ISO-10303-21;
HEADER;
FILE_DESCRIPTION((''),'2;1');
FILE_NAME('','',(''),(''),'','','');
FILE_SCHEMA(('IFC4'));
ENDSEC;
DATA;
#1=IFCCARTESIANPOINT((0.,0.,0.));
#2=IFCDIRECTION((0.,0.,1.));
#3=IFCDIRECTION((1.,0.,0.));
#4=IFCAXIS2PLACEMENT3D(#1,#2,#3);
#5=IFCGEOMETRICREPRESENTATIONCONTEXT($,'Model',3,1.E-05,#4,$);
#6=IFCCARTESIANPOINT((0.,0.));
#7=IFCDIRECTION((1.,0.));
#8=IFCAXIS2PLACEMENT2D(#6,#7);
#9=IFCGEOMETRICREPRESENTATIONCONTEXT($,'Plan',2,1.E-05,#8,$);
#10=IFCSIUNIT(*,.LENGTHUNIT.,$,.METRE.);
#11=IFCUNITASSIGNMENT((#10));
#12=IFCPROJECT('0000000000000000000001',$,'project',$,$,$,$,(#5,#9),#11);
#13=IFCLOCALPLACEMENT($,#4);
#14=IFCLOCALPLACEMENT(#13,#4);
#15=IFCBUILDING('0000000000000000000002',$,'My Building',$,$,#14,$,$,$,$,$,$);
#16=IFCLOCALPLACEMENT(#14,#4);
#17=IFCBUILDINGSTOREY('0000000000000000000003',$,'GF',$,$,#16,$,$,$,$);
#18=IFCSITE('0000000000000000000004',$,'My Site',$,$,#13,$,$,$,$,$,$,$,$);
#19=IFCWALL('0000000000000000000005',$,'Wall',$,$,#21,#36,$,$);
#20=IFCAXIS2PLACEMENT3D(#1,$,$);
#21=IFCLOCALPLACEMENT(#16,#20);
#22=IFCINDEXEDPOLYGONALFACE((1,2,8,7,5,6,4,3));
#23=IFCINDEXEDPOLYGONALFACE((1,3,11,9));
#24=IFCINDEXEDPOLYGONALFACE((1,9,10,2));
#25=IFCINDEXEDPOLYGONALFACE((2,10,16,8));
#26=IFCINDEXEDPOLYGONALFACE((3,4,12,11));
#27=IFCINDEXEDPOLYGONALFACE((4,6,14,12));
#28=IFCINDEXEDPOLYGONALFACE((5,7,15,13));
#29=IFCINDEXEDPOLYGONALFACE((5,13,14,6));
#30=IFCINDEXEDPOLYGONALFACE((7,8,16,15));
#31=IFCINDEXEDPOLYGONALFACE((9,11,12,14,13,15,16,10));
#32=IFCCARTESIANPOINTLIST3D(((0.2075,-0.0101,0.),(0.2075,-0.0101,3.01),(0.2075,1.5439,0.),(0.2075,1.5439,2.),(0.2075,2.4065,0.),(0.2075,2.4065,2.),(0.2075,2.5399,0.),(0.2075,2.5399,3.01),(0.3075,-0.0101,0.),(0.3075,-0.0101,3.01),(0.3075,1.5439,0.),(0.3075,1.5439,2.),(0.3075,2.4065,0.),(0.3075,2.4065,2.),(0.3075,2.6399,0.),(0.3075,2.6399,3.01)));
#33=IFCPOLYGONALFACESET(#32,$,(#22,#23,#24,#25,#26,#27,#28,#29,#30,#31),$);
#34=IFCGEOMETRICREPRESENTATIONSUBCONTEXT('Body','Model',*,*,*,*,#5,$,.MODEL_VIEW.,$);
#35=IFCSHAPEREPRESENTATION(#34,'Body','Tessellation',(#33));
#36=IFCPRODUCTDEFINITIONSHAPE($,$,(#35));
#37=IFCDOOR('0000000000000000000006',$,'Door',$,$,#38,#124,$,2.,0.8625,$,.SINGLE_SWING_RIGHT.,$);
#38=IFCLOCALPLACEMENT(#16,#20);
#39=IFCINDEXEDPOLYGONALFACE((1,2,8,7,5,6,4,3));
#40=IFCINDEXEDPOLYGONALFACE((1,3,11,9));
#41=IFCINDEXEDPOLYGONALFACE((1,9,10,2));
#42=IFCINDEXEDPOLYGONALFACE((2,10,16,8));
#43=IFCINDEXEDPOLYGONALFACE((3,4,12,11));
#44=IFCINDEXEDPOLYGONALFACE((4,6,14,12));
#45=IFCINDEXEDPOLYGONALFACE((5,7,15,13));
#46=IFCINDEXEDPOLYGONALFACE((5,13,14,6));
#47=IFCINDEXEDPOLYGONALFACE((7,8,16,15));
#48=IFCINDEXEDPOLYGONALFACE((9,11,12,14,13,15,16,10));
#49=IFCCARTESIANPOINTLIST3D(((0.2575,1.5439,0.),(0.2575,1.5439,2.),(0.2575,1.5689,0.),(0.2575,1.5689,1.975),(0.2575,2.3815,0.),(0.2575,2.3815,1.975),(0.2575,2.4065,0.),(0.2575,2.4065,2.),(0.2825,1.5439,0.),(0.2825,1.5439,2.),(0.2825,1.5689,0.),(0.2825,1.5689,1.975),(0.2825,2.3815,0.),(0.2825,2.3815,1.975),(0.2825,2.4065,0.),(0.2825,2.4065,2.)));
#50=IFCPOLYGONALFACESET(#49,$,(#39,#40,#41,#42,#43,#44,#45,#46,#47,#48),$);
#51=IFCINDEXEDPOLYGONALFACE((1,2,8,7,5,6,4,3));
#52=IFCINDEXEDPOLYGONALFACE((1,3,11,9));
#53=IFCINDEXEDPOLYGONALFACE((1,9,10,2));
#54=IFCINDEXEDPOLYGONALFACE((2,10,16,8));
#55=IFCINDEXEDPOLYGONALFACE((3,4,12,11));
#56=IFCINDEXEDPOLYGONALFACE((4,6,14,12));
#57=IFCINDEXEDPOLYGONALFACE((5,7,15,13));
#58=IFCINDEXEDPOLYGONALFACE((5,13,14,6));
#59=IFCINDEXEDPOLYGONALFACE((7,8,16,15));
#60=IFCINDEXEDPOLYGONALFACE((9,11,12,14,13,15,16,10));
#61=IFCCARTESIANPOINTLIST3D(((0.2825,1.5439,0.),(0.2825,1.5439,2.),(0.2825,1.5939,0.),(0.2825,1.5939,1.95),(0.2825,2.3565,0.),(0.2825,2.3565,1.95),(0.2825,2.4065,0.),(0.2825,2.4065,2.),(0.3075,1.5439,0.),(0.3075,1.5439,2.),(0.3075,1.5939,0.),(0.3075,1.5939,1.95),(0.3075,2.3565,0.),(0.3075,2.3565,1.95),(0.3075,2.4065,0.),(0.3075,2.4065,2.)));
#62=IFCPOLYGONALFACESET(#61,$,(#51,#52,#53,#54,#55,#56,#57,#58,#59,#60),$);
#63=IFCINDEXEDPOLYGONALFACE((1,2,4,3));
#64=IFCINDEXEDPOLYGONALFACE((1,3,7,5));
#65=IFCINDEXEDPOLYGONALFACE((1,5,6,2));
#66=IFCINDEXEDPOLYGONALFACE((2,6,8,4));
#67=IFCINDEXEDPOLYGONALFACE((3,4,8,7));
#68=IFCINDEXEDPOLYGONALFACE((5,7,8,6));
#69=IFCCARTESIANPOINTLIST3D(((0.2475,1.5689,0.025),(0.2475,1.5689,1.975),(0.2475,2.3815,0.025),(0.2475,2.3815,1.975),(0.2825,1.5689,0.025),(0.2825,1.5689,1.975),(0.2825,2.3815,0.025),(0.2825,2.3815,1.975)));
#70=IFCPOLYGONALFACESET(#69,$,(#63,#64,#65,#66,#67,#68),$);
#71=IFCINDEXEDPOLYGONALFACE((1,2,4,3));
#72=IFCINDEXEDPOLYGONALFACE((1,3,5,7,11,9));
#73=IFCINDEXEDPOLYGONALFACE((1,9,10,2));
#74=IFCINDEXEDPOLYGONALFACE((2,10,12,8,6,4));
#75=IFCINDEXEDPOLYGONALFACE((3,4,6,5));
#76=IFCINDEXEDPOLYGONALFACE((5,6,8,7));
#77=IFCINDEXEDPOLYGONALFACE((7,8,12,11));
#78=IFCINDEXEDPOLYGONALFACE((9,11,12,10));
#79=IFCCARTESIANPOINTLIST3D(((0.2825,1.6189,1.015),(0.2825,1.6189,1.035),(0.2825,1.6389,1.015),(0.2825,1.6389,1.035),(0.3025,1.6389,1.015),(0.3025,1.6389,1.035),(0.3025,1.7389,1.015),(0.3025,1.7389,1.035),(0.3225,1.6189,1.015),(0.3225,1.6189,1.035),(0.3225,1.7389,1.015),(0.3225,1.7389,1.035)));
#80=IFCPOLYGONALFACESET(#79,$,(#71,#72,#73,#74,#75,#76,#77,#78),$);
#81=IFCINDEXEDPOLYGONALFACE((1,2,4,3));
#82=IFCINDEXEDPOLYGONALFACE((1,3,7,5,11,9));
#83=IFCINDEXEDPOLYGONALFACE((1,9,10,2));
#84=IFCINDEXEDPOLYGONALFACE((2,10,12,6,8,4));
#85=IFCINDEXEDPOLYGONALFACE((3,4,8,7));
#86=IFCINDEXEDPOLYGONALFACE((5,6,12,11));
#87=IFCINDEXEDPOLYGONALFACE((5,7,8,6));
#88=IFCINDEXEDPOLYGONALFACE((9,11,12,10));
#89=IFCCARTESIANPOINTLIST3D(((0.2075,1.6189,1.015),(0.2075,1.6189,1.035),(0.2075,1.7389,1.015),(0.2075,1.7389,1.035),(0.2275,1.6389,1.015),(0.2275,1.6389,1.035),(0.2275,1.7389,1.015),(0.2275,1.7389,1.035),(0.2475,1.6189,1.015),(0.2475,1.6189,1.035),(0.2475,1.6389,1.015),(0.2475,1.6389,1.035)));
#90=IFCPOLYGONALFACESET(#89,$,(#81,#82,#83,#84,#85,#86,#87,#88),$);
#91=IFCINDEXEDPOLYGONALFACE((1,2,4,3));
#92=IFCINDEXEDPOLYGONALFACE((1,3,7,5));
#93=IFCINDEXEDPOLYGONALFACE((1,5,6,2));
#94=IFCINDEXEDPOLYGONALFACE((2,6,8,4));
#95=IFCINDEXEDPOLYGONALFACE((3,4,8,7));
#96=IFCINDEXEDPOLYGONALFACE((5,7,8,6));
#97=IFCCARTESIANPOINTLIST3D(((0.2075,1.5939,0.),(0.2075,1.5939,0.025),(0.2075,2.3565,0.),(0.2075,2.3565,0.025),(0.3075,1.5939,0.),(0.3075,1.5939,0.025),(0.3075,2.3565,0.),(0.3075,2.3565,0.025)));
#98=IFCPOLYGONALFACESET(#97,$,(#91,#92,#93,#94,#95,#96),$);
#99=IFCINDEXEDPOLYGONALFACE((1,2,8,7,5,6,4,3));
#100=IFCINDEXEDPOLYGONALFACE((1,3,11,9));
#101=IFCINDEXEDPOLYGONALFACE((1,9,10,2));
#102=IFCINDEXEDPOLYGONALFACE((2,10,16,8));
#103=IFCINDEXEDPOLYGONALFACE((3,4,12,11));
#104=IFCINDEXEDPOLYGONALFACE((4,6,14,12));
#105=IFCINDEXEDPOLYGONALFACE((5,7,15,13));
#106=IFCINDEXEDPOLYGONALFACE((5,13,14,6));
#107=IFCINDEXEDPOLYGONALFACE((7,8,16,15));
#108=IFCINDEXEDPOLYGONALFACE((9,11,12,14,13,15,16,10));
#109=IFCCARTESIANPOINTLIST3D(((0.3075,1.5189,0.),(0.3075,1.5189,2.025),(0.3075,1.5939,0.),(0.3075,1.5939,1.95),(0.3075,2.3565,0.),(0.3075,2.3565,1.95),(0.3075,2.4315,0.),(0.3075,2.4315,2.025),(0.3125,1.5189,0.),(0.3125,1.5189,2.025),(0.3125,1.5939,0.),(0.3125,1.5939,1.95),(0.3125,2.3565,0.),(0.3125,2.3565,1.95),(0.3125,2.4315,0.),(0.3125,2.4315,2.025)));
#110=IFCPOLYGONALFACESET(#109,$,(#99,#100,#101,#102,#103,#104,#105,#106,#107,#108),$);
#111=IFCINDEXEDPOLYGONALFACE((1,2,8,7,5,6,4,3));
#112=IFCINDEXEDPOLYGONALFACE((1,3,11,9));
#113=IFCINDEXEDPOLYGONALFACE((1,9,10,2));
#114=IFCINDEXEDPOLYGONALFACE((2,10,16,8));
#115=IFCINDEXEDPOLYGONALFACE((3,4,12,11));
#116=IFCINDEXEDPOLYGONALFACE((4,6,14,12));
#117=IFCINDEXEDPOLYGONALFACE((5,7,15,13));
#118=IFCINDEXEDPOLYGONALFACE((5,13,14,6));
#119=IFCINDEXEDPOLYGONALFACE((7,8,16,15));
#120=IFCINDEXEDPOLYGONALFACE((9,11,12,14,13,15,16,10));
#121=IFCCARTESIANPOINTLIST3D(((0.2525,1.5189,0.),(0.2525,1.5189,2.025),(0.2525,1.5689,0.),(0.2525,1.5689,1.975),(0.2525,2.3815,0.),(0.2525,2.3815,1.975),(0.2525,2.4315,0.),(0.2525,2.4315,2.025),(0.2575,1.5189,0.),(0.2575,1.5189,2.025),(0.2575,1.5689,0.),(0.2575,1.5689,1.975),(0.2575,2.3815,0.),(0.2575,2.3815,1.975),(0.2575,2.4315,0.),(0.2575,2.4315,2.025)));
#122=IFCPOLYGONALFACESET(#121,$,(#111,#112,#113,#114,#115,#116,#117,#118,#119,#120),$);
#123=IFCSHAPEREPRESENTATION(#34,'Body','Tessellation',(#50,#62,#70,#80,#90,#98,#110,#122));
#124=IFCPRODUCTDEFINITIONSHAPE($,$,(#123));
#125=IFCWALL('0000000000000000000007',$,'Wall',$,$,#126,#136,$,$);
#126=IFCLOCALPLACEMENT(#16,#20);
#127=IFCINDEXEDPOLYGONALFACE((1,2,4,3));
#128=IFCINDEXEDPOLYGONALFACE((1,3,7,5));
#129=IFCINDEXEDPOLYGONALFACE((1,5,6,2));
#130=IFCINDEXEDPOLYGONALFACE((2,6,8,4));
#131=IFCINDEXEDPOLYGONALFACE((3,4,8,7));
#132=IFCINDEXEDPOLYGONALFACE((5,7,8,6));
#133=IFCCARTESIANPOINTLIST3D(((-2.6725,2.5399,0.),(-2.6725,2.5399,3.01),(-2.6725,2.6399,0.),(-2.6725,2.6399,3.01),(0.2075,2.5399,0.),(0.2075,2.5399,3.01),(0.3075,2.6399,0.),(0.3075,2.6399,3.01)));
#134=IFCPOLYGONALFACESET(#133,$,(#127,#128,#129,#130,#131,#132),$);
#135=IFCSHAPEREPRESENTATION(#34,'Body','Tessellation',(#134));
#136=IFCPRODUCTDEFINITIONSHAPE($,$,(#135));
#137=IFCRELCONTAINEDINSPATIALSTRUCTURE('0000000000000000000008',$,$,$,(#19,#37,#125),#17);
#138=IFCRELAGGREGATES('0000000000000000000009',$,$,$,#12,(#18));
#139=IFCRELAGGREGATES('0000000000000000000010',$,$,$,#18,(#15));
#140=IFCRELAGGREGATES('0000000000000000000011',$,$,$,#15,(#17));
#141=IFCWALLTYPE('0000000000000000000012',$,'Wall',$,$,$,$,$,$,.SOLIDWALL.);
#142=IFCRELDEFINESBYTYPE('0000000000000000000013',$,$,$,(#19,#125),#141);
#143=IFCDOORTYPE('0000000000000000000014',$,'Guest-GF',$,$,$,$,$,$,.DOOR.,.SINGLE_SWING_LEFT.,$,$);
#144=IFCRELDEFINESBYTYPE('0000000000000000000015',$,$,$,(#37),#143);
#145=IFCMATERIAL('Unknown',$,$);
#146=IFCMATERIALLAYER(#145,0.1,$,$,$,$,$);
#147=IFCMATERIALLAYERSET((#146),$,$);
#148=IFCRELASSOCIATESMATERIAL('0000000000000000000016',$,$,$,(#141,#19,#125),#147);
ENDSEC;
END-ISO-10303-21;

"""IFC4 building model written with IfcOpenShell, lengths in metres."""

from ifc_helpers import new_model, entity, si_unit, frame, origin_with_axes, origin_2d_with_axis, place, context, subcontext, project, spatial, line, indexed_curve, outline, extrude, shape, source, transform, mapped, material, layer, layer_set, layer_usage, type_object, type_shapes, element, fill, save


model = new_model("IFC4")

# Units and contexts
model_context = context("Model", 3, precision=1e-05, world=origin_with_axes())
plan_context = context("Plan", 2, precision=1e-05, world=origin_2d_with_axis())
body_context_1 = subcontext(model_context, "Body", "Model", "MODEL_VIEW")
body_context_2 = subcontext(plan_context, "Body", "Plan", "PLAN_VIEW")
ifc_project = project(units=[si_unit("LENGTHUNIT", "METRE")], contexts=[model_context, plan_context])

# Site, building, storey
site_placement = place(None, origin_with_axes())
site = spatial("IfcSite", under=ifc_project, at=site_placement, Name="My Site")
building_placement = place(site_placement, origin_with_axes())
building = spatial("IfcBuilding", under=site, at=building_placement, Name="My Building")
storey_placement = place(building_placement, origin_with_axes())
storey = spatial("IfcBuildingStorey", under=building, at=storey_placement, Name="GF")

# Shared definitions
ifc_material = material(Name="Unknown")

# Shared definitions
ifc_layer_1 = layer(ifc_material, 0.1)
ifc_layer_set_1 = layer_set([ifc_layer_1])
wall_type = type_object("IfcWallType", Name="Wall", PredefinedType="SOLIDWALL", material=ifc_layer_set_1)

# Wall, opening, door
ifc_layer_usage_1 = layer_usage(ifc_layer_set_1, "AXIS2", "POSITIVE", 0.0)
wall_1_placement = place(storey_placement, frame((0.3075, -0.0101, 0.0), z_axis=(0.0, 0.0, 1.0), x_axis=(0.0, 1.0, 0.0)))
wall_1 = element("IfcWall", 1, at=wall_1_placement, inside=storey, type_object=wall_type, material=ifc_layer_usage_1, Name="Wall", context=body_context_1, shape_type="SweptSolid", body=[
    extrude(outline(indexed_curve([(0.0, 0.0), (0.0, 0.1), (2.55, 0.1), (2.65, 0.0)], segments=[line(1, 2, 3, 4, 1)])), origin_with_axes(), (0.0, 0.0, 1.0), 3.01),
])
shared_shape_1 = source(origin_with_axes(), body_context_1, "Body", "SweptSolid", [
    extrude(outline(indexed_curve([(0.0, 0.0), (0.8625, 0.0), (0.8625, 2.0), (0.0, 2.0)], segments=[line(1, 2, 3, 4, 1)])), frame((0.0, -0.6, 0.0), z_axis=(0.0, -1.0, 0.0), x_axis=(1.0, 0.0, 0.0)), (0.0, 0.0, -1.0), 1.2),
])
opening_1_placement = place(wall_1_placement, frame((1.554, 0.0, 0.0), z_axis=(0.0, 0.0, 1.0), x_axis=(1.0, 0.0, 0.0)))
opening_1 = element("IfcOpeningElement", 2, at=opening_1_placement, cuts=wall_1, PredefinedType="OPENING", context=body_context_1, shape_type="MappedRepresentation", body=[
    mapped(shared_shape_1, transform((0.0, 0.0, 0.0), x_axis=(1.0, 0.0, 0.0), y_axis=(0.0, 1.0, 0.0), z_axis=(0.0, 0.0, 1.0), scale=1.0)),
])
door_type_1 = type_object("IfcDoorType", Name="Guest-GF", OperationType="SINGLE_SWING_LEFT", PredefinedType="DOOR")
shared_shape_2 = source(origin_with_axes(), body_context_1, "Body", "SweptSolid", [
    extrude(outline(indexed_curve([(0.0, 0.0), (0.0, 2.0), (0.8625, 2.0), (0.8625, 0.0), (0.8375, 0.0), (0.8375, 1.975), (0.025, 1.975), (0.025, 0.0)], segments=[line(1, 2, 3, 4, 5, 6, 7, 8, 1)])), frame((0.0, 0.025, 0.0), z_axis=(0.0, -1.0, 0.0), x_axis=(1.0, 0.0, 0.0)), (0.0, 0.0, -1.0), 0.025),
    extrude(outline(indexed_curve([(0.0, 0.0), (0.0, 2.0), (0.8625, 2.0), (0.8625, 0.0), (0.8125, 0.0), (0.8125, 1.95), (0.05, 1.95), (0.05, 0.0)], segments=[line(1, 2, 3, 4, 5, 6, 7, 8, 1)])), frame((0.0, 0.0, 0.0), z_axis=(0.0, -1.0, 0.0), x_axis=(1.0, 0.0, 0.0)), (0.0, 0.0, -1.0), 0.025),
    extrude(outline(indexed_curve([(0.0, 0.0), (0.8125, 0.0), (0.8125, 0.035), (0.0, 0.035)], segments=[line(1, 2, 3, 4, 1)])), frame((0.025, 0.025, 0.025), z_axis=(0.0, 0.0, 1.0), x_axis=(1.0, 0.0, 0.0)), (0.0, 0.0, 1.0), 1.95),
    extrude(outline(indexed_curve([(0.0, 0.0), (0.0, -0.04), (0.12, -0.04), (0.12, -0.02), (0.02, -0.02), (0.02, 0.0)], segments=[line(1, 2, 3, 4, 5, 6, 1)])), frame((0.075, 0.025, 1.015), z_axis=(0.0, 0.0, 1.0), x_axis=(1.0, 0.0, 0.0)), (0.0, 0.0, 1.0), 0.02),
    extrude(outline(indexed_curve([(0.0, 0.0), (0.0, 0.04), (0.12, 0.04), (0.12, 0.02), (0.02, 0.02), (0.02, 0.0)], segments=[line(1, 2, 3, 4, 5, 6, 1)])), frame((0.075, 0.06, 1.015), z_axis=(0.0, 0.0, 1.0), x_axis=(1.0, 0.0, 0.0)), (0.0, 0.0, 1.0), 0.02),
    extrude(outline(indexed_curve([(0.0, 0.0), (0.7625, 0.0), (0.7625, 0.1), (0.0, 0.1)], segments=[line(1, 2, 3, 4, 1)])), frame((0.05, 0.0, 0.0), z_axis=(0.0, 0.0, 1.0), x_axis=(1.0, 0.0, 0.0)), (0.0, 0.0, 1.0), 0.025),
    extrude(outline(indexed_curve([(0.0, 0.0), (0.0, 2.025), (0.9125, 2.025), (0.9125, 0.0), (0.8375, 0.0), (0.8375, 1.95), (0.075, 1.95), (0.075, 0.0)], segments=[line(1, 2, 3, 4, 5, 6, 7, 8, 1)])), frame((-0.025, -0.005, 0.0), z_axis=(0.0, -1.0, 0.0), x_axis=(1.0, 0.0, 0.0)), (0.0, 0.0, -1.0), 0.005),
    extrude(outline(indexed_curve([(0.0, 0.0), (0.0, 2.025), (0.9125, 2.025), (0.9125, 0.0), (0.8625, 0.0), (0.8625, 1.975), (0.05, 1.975), (0.05, 0.0)], segments=[line(1, 2, 3, 4, 5, 6, 7, 8, 1)])), frame((-0.025, 0.05, 0.0), z_axis=(0.0, -1.0, 0.0), x_axis=(1.0, 0.0, 0.0)), (0.0, 0.0, -1.0), 0.005),
])
shared_shape_3 = source(origin_with_axes(), body_context_2, "Body", "Curve2D", [
    entity("IfcIndexedPolyCurve", entity("IfcCartesianPointList2D", [[0.0, 0.0], [0.0, 0.05], [0.025, 0.05], [0.025, 0.025], [0.05, 0.025], [0.05, 0.0]]), [entity("IfcLineIndex", [1, 2, 3, 4, 5, 6, 1])]),
    entity("IfcIndexedPolyCurve", entity("IfcCartesianPointList2D", [[0.8625, 0.0], [0.8625, 0.05], [0.8375, 0.05], [0.8375, 0.025], [0.8125, 0.025], [0.8125, 0.0]]), [entity("IfcLineIndex", [1, 2, 3, 4, 5, 6, 1])]),
    entity("IfcTrimmedCurve", entity("IfcEllipse", entity("IfcAxis2Placement2D", entity("IfcCartesianPoint", [0.8025, 0.05]), entity("IfcDirection", [1.0, 0.0])), 0.7775, 0.8125), [entity("IfcCartesianPoint", [0.8025, 0.8625])], [entity("IfcCartesianPoint", [0.025, 0.05])], True, "CARTESIAN"),
    entity("IfcIndexedPolyCurve", entity("IfcCartesianPointList2D", [[0.8375, 0.05], [0.8025, 0.05], [0.8025, 0.8625], [0.8375, 0.8625]]), [entity("IfcLineIndex", [1, 2, 3, 4, 1])]),
])
type_shapes(door_type_1, [shared_shape_2, shared_shape_3])
door_1_placement = place(opening_1_placement, frame((0.0, 0.0, 0.0), z_axis=(0.0, 0.0, 1.0), x_axis=(1.0, 0.0, 0.0)))
door_1 = element("IfcDoor", 3, at=door_1_placement, inside=storey, type_object=door_type_1, Name="Door", OperationType="SINGLE_SWING_RIGHT", OverallHeight=2.0, OverallWidth=0.8625, shapes=[
    shape(body_context_1, "Body", "MappedRepresentation", [mapped(shared_shape_2, transform((0.0, 0.0, 0.0), x_axis=(1.0, 0.0, 0.0), y_axis=(0.0, 1.0, 0.0), z_axis=(0.0, 0.0, 1.0), scale=1.0))]),
    shape(body_context_2, "Body", "MappedRepresentation", [mapped(shared_shape_3, transform((0.0, 0.0, 0.0), x_axis=(1.0, 0.0, 0.0), y_axis=(0.0, 1.0, 0.0), z_axis=(0.0, 0.0, 1.0), scale=1.0))]),
])
fill(opening_1, door_1)

# Wall
ifc_layer_usage_2 = layer_usage(ifc_layer_set_1, "AXIS2", "POSITIVE", 0.0)
wall_2_placement = place(storey_placement, frame((0.3075, 2.6399, 0.0), z_axis=(0.0, 0.0, 1.0), x_axis=(-1.0, 0.0, 0.0)))
element("IfcWall", 4, at=wall_2_placement, inside=storey, type_object=wall_type, material=ifc_layer_usage_2, Name="Wall", context=body_context_1, shape_type="SweptSolid", body=[
    extrude(outline(indexed_curve([(0.0, 0.0), (0.1, 0.1), (2.98, 0.1), (2.98, 0.0)], segments=[line(1, 2, 3, 4, 1)])), origin_with_axes(), (0.0, 0.0, 1.0), 3.01),
])

save(model, "model.ifc")
